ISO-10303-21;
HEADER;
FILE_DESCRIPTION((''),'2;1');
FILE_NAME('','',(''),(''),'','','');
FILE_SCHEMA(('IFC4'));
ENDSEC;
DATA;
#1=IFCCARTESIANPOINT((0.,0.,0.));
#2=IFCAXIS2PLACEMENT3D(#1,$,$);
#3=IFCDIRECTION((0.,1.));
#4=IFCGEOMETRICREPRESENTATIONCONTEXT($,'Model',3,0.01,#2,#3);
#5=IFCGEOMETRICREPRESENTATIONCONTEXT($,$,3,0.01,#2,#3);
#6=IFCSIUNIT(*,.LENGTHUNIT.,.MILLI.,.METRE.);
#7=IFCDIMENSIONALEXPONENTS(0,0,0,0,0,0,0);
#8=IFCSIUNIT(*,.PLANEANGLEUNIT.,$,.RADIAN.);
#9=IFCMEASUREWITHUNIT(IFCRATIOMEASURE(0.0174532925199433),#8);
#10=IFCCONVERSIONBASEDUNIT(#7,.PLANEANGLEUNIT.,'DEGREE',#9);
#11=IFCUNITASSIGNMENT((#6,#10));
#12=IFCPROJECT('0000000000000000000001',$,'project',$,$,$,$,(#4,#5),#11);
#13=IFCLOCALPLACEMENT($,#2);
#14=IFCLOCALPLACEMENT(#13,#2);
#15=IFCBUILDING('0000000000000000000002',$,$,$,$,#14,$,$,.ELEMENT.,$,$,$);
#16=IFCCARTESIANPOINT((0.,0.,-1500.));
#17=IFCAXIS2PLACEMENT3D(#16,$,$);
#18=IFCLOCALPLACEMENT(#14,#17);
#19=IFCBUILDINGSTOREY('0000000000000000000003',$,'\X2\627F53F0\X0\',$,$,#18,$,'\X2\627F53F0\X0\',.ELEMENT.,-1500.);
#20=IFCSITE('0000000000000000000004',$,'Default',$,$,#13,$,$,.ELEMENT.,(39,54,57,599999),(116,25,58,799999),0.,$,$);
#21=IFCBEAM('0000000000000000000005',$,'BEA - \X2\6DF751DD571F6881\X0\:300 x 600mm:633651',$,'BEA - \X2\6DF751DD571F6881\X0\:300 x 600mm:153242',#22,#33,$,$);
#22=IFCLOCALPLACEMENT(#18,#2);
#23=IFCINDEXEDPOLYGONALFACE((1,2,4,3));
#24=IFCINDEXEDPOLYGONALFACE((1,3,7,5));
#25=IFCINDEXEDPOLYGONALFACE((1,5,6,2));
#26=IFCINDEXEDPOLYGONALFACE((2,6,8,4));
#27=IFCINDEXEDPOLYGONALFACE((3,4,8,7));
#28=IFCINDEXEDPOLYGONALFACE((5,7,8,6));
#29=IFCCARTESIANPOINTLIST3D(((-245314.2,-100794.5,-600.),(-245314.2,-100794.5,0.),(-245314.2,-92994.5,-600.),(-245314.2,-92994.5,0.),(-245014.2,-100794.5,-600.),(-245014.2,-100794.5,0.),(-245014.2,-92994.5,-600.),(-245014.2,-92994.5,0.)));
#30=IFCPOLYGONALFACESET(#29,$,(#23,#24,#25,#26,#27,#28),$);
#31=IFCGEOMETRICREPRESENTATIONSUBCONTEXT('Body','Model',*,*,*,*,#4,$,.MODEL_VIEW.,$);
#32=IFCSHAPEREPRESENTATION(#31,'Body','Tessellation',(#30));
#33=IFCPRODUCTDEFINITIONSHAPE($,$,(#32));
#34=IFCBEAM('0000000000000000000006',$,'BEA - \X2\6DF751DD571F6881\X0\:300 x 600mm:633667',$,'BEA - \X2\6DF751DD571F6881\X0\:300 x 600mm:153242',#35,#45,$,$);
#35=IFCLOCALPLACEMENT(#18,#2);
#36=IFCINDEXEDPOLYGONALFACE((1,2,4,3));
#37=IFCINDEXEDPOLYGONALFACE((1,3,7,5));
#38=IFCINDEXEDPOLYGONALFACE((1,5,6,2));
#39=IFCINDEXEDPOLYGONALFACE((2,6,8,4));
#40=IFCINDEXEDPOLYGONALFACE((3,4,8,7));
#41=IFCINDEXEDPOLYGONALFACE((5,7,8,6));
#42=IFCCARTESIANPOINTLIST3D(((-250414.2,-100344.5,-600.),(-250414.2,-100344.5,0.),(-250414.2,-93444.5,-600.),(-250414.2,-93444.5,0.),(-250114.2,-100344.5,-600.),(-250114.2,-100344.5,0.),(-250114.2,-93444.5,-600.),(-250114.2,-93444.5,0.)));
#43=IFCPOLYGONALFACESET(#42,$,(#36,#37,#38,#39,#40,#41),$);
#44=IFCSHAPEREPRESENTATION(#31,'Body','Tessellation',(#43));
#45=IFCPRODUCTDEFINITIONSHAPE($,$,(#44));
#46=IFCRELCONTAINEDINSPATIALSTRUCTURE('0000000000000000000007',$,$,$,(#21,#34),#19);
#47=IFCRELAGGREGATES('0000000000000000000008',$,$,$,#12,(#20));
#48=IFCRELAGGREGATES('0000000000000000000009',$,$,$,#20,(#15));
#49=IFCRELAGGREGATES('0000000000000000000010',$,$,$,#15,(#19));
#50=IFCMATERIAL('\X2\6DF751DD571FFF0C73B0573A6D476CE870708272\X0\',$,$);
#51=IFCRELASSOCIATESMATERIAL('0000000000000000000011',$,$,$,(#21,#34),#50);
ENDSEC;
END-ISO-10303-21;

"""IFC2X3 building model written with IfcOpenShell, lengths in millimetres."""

from ifc_helpers import new_model, entity, si_unit, converted_unit, direction, frame, frame_2d, origin, origin_2d_with_axis, place, context, subcontext, project, spatial, rectangle, extrude, material, element, save


model = new_model("IFC2X3")

# Units and contexts
model_context = context("Model", 3, precision=0.01, world=origin(), true_north=direction((0.0, 1.0)))
context_of_model = context(None, 3, precision=0.01, world=origin(), true_north=direction((0.0, 1.0)))
body_context = subcontext(model_context, "Body", "Model", "MODEL_VIEW")
ifc_project = project(units=[si_unit("LENGTHUNIT", "METRE", prefix="MILLI"), converted_unit("PLANEANGLEUNIT", "DEGREE", entity("IfcRatioMeasure", 0.0174532925199433), si_unit("PLANEANGLEUNIT", "RADIAN"), dimensions=[0, 0, 0, 0, 0, 0, 0])], contexts=[model_context, context_of_model])

# Site, building, storey
site_placement = place(None, origin())
site = spatial("IfcSite", under=ifc_project, at=site_placement, Name="Default", CompositionType="ELEMENT", RefLatitude=(39, 54, 57, 599999), RefLongitude=(116, 25, 58, 799999), RefElevation=0.0)
building_placement = place(site_placement, origin())
building = spatial("IfcBuilding", under=site, at=building_placement, CompositionType="ELEMENT")
storey_placement = place(building_placement, frame((0.0, 0.0, -1500.0)))
storey = spatial("IfcBuildingStorey", under=building, at=storey_placement, Name="承台", LongName="承台", CompositionType="ELEMENT", Elevation=-1500.0)

# Shared definitions
ifc_material_1 = material(Name="混凝土，现场浇注灰色")

# Beams
beam_1_placement = place(storey_placement, frame((-245164.2, -100794.5, 0.0), z_axis=(0.0, 0.0, 1.0), x_axis=(0.0, 1.0, 0.0)))
element("IfcBeam", 1, at=beam_1_placement, inside=storey, material=ifc_material_1, Name="BEA - 混凝土梁:300 x 600mm:633651", ObjectType="BEA - 混凝土梁:300 x 600mm:153242", context=body_context, shape_type="SweptSolid", body=[
    extrude(rectangle(XDim=600.0, YDim=300.0, at=origin_2d_with_axis()), frame((0.0, 0.0, -300.0), z_axis=(1.0, 0.0, 0.0), x_axis=(0.0, 0.0, -1.0)), (0.0, 0.0, 1.0), 7800.0),
])
beam_2_placement = place(storey_placement, frame((-250264.2, -100344.5, 0.0), z_axis=(0.0, 0.0, 1.0), x_axis=(0.0, 1.0, 0.0)))
element("IfcBeam", 2, at=beam_2_placement, inside=storey, material=ifc_material_1, Name="BEA - 混凝土梁:300 x 600mm:633667", ObjectType="BEA - 混凝土梁:300 x 600mm:153242", context=body_context, shape_type="SweptSolid", body=[
    extrude(rectangle(XDim=600.0, YDim=300.0, at=frame_2d((0.0, 0.0), x_axis=(1.0, 0.0))), frame((0.0, 0.0, -300.0), z_axis=(1.0, 0.0, 0.0), x_axis=(0.0, 0.0, -1.0)), (0.0, 0.0, 1.0), 6900.0),
])

save(model, "model.ifc")
